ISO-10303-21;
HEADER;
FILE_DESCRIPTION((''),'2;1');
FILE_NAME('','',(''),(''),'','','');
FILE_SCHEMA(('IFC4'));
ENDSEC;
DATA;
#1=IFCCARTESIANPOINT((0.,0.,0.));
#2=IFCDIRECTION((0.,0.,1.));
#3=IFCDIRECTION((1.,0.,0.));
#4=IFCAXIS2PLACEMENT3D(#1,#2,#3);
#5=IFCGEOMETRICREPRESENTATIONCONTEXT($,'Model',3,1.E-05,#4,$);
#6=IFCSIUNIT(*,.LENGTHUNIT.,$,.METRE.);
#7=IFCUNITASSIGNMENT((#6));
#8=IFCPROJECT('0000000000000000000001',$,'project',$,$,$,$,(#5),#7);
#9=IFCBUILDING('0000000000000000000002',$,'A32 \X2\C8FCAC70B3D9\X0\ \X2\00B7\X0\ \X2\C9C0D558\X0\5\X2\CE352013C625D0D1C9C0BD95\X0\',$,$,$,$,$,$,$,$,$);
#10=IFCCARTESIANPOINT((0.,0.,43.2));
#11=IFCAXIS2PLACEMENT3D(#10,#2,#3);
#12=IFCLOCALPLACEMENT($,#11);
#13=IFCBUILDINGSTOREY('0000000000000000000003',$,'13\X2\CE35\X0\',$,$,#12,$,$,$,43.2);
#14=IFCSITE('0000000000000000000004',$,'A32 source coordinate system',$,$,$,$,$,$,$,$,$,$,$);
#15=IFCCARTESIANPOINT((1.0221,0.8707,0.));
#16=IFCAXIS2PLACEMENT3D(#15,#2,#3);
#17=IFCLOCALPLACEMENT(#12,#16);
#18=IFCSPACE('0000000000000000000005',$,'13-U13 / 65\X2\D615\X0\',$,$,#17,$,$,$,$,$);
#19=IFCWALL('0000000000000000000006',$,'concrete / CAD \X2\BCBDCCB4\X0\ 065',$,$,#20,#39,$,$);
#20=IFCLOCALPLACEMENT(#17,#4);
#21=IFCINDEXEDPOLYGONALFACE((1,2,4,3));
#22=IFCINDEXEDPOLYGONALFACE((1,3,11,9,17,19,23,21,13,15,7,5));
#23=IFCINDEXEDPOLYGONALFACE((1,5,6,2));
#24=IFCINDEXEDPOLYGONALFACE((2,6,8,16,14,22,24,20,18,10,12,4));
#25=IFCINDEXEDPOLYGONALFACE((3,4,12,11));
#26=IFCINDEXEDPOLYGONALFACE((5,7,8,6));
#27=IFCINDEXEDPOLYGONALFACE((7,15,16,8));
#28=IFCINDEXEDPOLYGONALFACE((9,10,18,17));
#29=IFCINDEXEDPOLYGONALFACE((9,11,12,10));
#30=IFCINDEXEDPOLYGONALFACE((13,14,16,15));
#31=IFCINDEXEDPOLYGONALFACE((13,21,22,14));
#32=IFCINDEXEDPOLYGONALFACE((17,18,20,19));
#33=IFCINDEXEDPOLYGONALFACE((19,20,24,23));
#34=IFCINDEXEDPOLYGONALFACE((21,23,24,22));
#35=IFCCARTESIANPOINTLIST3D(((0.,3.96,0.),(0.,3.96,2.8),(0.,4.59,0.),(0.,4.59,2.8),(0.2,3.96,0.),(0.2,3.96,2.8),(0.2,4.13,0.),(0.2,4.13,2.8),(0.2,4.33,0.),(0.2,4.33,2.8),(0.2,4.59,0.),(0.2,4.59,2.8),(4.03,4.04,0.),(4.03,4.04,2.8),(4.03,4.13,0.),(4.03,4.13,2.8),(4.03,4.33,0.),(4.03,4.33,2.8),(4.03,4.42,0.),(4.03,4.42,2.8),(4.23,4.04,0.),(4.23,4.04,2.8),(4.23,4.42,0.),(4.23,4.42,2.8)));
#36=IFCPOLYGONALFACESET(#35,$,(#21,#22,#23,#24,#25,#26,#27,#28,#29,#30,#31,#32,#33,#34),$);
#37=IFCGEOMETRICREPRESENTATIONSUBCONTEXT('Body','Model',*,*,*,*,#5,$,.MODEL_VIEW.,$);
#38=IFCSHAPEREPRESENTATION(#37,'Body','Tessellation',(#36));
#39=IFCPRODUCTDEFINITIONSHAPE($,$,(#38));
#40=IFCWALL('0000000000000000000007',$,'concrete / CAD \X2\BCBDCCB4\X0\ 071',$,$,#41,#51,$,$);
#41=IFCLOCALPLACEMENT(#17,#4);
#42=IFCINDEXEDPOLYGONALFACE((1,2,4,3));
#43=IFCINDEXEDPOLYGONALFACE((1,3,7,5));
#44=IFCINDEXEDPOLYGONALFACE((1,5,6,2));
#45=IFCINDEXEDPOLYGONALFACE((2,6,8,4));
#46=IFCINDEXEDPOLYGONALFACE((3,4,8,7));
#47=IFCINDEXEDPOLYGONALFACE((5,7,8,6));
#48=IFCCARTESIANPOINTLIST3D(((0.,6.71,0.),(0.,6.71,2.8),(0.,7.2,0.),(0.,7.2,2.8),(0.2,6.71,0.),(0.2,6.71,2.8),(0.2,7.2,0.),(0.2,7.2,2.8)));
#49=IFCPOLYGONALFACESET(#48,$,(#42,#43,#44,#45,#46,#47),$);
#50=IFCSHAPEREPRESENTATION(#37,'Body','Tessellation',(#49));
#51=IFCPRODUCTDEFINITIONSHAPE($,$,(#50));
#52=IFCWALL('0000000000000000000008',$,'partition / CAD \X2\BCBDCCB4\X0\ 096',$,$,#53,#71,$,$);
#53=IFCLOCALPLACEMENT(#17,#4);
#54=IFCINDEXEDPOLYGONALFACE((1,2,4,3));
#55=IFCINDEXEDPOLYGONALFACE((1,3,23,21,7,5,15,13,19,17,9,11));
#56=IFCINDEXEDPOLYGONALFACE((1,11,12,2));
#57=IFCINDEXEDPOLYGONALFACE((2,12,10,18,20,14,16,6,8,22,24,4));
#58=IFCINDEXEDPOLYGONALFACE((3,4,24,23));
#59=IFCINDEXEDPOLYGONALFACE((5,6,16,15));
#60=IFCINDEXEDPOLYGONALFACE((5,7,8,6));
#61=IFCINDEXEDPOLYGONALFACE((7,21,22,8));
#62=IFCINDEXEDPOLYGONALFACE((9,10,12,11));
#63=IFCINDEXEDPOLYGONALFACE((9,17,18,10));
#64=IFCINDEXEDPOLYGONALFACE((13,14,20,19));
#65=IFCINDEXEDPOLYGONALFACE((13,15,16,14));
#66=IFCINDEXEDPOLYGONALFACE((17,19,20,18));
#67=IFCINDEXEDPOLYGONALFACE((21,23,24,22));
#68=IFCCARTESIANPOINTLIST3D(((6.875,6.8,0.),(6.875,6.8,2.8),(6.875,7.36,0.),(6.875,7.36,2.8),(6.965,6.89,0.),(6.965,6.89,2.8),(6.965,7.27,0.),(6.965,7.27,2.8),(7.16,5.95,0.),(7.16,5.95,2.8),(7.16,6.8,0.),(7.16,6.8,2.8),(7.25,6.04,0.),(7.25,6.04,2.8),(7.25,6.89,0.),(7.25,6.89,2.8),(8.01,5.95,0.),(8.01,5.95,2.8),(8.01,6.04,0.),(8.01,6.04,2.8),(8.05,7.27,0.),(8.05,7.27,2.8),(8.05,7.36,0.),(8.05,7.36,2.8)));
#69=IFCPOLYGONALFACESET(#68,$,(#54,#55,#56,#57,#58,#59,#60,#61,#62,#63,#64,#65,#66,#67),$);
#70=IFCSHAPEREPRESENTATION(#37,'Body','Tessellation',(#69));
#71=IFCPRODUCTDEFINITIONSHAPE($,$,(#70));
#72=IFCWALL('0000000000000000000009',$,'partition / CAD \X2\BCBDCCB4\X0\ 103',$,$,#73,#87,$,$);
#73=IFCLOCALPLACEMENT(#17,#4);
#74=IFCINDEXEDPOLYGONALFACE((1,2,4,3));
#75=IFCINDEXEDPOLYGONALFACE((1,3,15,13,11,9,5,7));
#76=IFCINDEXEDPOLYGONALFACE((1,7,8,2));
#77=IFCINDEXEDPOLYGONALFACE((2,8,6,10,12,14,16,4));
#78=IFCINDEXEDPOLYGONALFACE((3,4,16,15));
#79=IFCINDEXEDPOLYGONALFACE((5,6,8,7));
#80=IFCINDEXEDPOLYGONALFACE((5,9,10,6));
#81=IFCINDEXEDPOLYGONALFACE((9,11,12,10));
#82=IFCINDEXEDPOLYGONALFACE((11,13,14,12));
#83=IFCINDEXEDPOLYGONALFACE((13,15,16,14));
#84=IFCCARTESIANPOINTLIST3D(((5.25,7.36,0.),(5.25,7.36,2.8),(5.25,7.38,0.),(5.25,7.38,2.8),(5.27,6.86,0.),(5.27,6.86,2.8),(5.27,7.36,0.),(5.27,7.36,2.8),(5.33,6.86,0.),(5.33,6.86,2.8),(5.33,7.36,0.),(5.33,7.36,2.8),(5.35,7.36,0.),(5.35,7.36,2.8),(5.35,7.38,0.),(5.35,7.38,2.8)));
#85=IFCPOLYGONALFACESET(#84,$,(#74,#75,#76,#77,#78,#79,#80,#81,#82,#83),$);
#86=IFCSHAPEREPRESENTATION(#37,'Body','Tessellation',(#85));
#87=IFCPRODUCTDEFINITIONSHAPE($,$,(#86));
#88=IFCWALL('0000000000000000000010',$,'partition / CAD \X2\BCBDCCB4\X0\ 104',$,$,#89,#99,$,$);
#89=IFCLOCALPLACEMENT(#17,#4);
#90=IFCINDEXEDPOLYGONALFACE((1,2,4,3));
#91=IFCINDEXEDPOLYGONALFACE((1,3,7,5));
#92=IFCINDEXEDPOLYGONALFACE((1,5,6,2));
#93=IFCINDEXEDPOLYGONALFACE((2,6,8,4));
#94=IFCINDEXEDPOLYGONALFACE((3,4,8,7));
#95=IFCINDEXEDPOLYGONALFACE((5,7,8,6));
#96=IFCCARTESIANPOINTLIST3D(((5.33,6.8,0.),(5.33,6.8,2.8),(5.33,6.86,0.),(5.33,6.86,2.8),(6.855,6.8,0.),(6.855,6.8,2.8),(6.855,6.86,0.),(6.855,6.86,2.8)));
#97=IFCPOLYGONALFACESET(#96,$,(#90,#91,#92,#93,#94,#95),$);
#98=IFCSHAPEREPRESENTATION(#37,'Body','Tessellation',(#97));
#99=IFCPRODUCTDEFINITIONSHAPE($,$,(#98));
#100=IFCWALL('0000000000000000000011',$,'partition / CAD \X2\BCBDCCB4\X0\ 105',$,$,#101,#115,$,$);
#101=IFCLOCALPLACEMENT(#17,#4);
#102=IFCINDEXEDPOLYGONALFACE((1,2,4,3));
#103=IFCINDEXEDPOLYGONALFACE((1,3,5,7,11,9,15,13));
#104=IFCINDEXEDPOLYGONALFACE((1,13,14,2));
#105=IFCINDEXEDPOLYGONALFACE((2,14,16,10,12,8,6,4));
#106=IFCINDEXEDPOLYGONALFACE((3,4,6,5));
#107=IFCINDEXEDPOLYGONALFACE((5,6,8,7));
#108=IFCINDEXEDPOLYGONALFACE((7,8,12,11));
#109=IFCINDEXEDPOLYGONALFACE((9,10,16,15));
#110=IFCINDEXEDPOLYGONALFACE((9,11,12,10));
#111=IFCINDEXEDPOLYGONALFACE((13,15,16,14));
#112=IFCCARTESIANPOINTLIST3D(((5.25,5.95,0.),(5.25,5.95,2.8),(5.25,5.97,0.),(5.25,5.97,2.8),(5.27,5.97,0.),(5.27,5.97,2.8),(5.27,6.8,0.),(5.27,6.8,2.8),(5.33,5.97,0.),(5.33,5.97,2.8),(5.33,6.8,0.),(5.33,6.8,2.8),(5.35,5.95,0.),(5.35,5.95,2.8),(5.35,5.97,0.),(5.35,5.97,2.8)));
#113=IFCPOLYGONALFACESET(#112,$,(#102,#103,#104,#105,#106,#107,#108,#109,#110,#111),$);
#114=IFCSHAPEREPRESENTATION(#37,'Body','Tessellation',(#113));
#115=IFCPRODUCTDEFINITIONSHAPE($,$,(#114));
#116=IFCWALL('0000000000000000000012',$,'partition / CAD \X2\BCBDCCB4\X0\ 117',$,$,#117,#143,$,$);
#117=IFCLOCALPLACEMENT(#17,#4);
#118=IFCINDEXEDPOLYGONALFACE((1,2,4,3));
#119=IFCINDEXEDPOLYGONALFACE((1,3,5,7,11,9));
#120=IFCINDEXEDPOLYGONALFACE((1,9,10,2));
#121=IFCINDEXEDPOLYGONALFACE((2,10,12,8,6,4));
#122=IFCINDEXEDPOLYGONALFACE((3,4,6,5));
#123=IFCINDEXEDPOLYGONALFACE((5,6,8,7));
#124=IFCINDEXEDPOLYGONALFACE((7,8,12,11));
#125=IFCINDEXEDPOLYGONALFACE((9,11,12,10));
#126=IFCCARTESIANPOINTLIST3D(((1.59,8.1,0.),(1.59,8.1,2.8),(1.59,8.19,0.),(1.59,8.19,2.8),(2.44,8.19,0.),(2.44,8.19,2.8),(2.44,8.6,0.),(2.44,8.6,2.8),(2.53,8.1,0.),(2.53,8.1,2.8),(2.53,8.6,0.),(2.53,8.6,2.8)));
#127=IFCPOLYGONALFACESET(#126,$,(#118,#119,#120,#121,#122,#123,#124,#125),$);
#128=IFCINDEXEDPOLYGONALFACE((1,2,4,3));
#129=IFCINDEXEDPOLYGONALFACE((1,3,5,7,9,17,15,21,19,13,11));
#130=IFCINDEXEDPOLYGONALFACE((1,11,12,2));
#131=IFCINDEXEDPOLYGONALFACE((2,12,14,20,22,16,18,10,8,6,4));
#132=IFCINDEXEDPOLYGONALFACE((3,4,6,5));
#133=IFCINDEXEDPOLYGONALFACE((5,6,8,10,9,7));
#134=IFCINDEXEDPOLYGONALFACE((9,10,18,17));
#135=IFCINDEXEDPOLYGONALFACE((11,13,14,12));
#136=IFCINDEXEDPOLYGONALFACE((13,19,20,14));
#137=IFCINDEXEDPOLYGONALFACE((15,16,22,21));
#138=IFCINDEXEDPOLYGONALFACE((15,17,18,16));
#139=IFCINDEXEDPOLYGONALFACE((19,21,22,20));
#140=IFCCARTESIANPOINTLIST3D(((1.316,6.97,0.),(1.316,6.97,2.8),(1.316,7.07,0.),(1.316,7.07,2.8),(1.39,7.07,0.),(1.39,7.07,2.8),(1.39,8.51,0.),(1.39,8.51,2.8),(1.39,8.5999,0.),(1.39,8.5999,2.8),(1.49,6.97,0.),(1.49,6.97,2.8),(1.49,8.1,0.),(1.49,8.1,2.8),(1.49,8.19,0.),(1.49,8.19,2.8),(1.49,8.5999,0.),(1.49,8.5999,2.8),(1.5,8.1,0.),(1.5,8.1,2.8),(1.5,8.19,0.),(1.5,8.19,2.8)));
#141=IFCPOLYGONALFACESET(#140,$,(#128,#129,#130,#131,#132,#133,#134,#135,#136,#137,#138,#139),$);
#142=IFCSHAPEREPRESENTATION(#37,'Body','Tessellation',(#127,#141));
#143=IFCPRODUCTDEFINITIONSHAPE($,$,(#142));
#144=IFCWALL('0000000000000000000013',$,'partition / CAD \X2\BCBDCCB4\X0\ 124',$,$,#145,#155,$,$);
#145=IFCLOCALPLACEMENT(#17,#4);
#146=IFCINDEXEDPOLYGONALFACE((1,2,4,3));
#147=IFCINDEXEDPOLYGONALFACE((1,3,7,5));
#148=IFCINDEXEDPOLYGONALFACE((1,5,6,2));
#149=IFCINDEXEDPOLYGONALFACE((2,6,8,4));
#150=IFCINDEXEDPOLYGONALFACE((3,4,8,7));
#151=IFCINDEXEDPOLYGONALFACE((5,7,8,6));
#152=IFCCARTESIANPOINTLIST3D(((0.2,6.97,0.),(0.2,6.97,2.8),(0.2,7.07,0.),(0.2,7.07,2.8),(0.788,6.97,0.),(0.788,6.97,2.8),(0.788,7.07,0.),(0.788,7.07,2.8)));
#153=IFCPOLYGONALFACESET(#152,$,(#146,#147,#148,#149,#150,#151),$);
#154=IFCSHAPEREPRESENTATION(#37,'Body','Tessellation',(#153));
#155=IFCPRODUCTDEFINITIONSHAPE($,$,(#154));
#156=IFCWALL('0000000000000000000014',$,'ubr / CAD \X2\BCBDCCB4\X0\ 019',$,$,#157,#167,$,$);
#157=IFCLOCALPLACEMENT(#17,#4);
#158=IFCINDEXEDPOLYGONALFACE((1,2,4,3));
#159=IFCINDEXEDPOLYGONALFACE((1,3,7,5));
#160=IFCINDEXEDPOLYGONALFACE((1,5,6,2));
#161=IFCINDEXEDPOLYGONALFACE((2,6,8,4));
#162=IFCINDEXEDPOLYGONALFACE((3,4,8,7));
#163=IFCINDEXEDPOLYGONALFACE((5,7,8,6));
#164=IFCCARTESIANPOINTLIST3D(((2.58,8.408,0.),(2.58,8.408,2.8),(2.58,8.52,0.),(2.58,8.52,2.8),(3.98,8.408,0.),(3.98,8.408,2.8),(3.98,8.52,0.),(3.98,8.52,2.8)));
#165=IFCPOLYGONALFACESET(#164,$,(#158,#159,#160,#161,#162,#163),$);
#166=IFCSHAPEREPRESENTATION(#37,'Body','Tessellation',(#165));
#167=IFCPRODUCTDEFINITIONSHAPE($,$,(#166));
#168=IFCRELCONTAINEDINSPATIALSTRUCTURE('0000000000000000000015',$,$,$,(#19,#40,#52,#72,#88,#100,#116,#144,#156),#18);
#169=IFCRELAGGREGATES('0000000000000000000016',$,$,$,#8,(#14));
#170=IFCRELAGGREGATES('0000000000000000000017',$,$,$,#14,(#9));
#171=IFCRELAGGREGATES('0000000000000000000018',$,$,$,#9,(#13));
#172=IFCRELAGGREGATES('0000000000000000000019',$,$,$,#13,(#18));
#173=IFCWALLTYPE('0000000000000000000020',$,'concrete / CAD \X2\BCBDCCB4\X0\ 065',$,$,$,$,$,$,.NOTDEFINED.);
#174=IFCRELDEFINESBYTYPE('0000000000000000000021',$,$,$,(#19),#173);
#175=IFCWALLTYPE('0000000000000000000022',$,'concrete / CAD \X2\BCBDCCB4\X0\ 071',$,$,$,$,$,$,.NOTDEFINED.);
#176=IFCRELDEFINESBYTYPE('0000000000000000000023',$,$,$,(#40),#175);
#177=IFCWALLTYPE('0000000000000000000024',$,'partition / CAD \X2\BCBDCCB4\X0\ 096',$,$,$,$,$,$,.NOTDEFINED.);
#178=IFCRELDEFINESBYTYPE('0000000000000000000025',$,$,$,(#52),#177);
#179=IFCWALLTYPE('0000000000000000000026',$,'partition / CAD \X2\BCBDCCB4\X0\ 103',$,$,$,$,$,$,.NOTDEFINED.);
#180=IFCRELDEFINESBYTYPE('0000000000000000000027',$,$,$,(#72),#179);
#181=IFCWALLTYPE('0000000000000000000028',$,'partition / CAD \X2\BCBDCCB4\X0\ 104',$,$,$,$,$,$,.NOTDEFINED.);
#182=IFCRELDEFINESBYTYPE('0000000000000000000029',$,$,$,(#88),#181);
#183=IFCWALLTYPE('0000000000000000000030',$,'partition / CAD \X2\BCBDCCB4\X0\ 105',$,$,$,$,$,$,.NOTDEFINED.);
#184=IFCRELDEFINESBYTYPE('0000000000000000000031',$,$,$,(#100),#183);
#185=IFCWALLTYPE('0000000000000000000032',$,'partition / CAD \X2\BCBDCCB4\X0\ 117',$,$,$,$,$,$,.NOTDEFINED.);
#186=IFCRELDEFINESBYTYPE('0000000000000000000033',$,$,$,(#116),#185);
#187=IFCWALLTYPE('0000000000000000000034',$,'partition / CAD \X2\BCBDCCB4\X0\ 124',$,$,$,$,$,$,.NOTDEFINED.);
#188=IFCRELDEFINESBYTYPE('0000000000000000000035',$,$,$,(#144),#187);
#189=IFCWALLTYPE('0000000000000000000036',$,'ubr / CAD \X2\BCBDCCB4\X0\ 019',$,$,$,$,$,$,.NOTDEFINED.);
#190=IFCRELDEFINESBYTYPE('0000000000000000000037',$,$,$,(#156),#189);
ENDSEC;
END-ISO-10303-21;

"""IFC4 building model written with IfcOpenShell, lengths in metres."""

from ifc_helpers import new_model, si_unit, frame, origin, origin_with_axes, place, context, subcontext, project, spatial, polyline, outline, extrude, source, transform, mapped, type_object, type_shapes, element, save


model = new_model("IFC4")

# Units and contexts
model_context = context("Model", 3, precision=1e-05, world=origin_with_axes())
body_context = subcontext(model_context, "Body", "Model", "MODEL_VIEW")
ifc_project = project(units=[si_unit("LENGTHUNIT", "METRE")], contexts=[model_context])

# Site, building, storey, space
storey_placement = place(None, frame((0.0, 0.0, 43.2), z_axis=(0.0, 0.0, 1.0), x_axis=(1.0, 0.0, 0.0)))
space_placement = place(storey_placement, frame((1.0221, 0.8707, 0.0), z_axis=(0.0, 0.0, 1.0), x_axis=(1.0, 0.0, 0.0)))
site = spatial("IfcSite", under=ifc_project, Name="A32 source coordinate system")
building = spatial("IfcBuilding", under=site, Name="A32 주거동 · 지하5층–옥탑지붕")
storey = spatial("IfcBuildingStorey", under=building, at=storey_placement, Name="13층", Elevation=43.2)
space = spatial("IfcSpace", under=storey, at=space_placement, Name="13-U13 / 65형")

# Walls
wall_type_1 = type_object("IfcWallType", Name="concrete / CAD 벽체 065", PredefinedType="NOTDEFINED")
shared_shape_1 = source(origin(), body_context, "Body", "SweptSolid", [
    extrude(outline(polyline([(0.2, 4.59), (0.2, 4.33), (4.03, 4.33), (4.03, 4.42), (4.23, 4.42), (4.23, 4.04), (4.03, 4.04), (4.03, 4.13), (0.2, 4.13), (0.2, 3.96), (0.0, 3.96), (0.0, 4.59), (0.2, 4.59)])), origin(), (0.0, 0.0, 1.0), 2.8),
])
type_shapes(wall_type_1, [shared_shape_1])
wall_1_placement = place(space_placement, origin_with_axes())
element("IfcWall", 1, at=wall_1_placement, inside=space, type_object=wall_type_1, Name="concrete / CAD 벽체 065", context=body_context, shape_type="MappedRepresentation", body=[
    mapped(shared_shape_1, transform((0.0, 0.0, 0.0), scale=1.0)),
])
wall_type_2 = type_object("IfcWallType", Name="concrete / CAD 벽체 071", PredefinedType="NOTDEFINED")
shared_shape_2 = source(origin(), body_context, "Body", "SweptSolid", [
    extrude(outline(polyline([(0.2, 6.71), (0.0, 6.71), (0.0, 7.2), (0.2, 7.2), (0.2, 6.71)])), origin(), (0.0, 0.0, 1.0), 2.8),
])
type_shapes(wall_type_2, [shared_shape_2])
wall_2_placement = place(space_placement, origin_with_axes())
element("IfcWall", 2, at=wall_2_placement, inside=space, type_object=wall_type_2, Name="concrete / CAD 벽체 071", context=body_context, shape_type="MappedRepresentation", body=[
    mapped(shared_shape_2, transform((0.0, 0.0, 0.0), scale=1.0)),
])
wall_type_3 = type_object("IfcWallType", Name="partition / CAD 벽체 096", PredefinedType="NOTDEFINED")
shared_shape_3 = source(origin(), body_context, "Body", "SweptSolid", [
    extrude(outline(polyline([(7.25, 6.04), (8.01, 6.04), (8.01, 5.95), (7.16, 5.95), (7.16, 6.8), (6.875, 6.8), (6.875, 7.36), (8.05, 7.36), (8.05, 7.27), (6.965, 7.27), (6.965, 6.89), (7.25, 6.89), (7.25, 6.04)])), origin(), (0.0, 0.0, 1.0), 2.8),
])
type_shapes(wall_type_3, [shared_shape_3])
wall_3_placement = place(space_placement, origin_with_axes())
element("IfcWall", 3, at=wall_3_placement, inside=space, type_object=wall_type_3, Name="partition / CAD 벽체 096", context=body_context, shape_type="MappedRepresentation", body=[
    mapped(shared_shape_3, transform((0.0, 0.0, 0.0), scale=1.0)),
])
wall_type_4 = type_object("IfcWallType", Name="partition / CAD 벽체 103", PredefinedType="NOTDEFINED")
shared_shape_4 = source(origin(), body_context, "Body", "SweptSolid", [
    extrude(outline(polyline([(5.27, 7.36), (5.25, 7.36), (5.25, 7.38), (5.35, 7.38), (5.35, 7.36), (5.33, 7.36), (5.33, 6.86), (5.27, 6.86), (5.27, 7.36)])), origin(), (0.0, 0.0, 1.0), 2.8),
])
type_shapes(wall_type_4, [shared_shape_4])
wall_4_placement = place(space_placement, origin_with_axes())
element("IfcWall", 4, at=wall_4_placement, inside=space, type_object=wall_type_4, Name="partition / CAD 벽체 103", context=body_context, shape_type="MappedRepresentation", body=[
    mapped(shared_shape_4, transform((0.0, 0.0, 0.0), scale=1.0)),
])
wall_type_5 = type_object("IfcWallType", Name="partition / CAD 벽체 104", PredefinedType="NOTDEFINED")
shared_shape_5 = source(origin(), body_context, "Body", "SweptSolid", [
    extrude(outline(polyline([(6.855, 6.86), (6.855, 6.8), (5.33, 6.8), (5.33, 6.86), (6.855, 6.86)])), origin(), (0.0, 0.0, 1.0), 2.8),
])
type_shapes(wall_type_5, [shared_shape_5])
wall_5_placement = place(space_placement, origin_with_axes())
element("IfcWall", 5, at=wall_5_placement, inside=space, type_object=wall_type_5, Name="partition / CAD 벽체 104", context=body_context, shape_type="MappedRepresentation", body=[
    mapped(shared_shape_5, transform((0.0, 0.0, 0.0), scale=1.0)),
])
wall_type_6 = type_object("IfcWallType", Name="partition / CAD 벽체 105", PredefinedType="NOTDEFINED")
shared_shape_6 = source(origin(), body_context, "Body", "SweptSolid", [
    extrude(outline(polyline([(5.25, 5.97), (5.27, 5.97), (5.27, 6.8), (5.33, 6.8), (5.33, 5.97), (5.35, 5.97), (5.35, 5.95), (5.25, 5.95), (5.25, 5.97)])), origin(), (0.0, 0.0, 1.0), 2.8),
])
type_shapes(wall_type_6, [shared_shape_6])
wall_6_placement = place(space_placement, origin_with_axes())
element("IfcWall", 6, at=wall_6_placement, inside=space, type_object=wall_type_6, Name="partition / CAD 벽체 105", context=body_context, shape_type="MappedRepresentation", body=[
    mapped(shared_shape_6, transform((0.0, 0.0, 0.0), scale=1.0)),
])
wall_type_7 = type_object("IfcWallType", Name="partition / CAD 벽체 117", PredefinedType="NOTDEFINED")
shared_shape_7 = source(origin(), body_context, "Body", "SweptSolid", [
    extrude(outline(polyline([(2.53, 8.1), (1.59, 8.1), (1.59, 8.19), (2.44, 8.19), (2.44, 8.6), (2.53, 8.6), (2.53, 8.1)])), origin(), (0.0, 0.0, 1.0), 2.8),
    extrude(outline(polyline([(1.49, 8.1), (1.49, 6.97), (1.316, 6.97), (1.316, 7.07), (1.39, 7.07), (1.39, 8.51), (1.39, 8.5999), (1.49, 8.5999), (1.49, 8.19), (1.5, 8.19), (1.5, 8.1), (1.49, 8.1)])), origin(), (0.0, 0.0, 1.0), 2.8),
])
type_shapes(wall_type_7, [shared_shape_7])
wall_7_placement = place(space_placement, origin_with_axes())
element("IfcWall", 7, at=wall_7_placement, inside=space, type_object=wall_type_7, Name="partition / CAD 벽체 117", context=body_context, shape_type="MappedRepresentation", body=[
    mapped(shared_shape_7, transform((0.0, 0.0, 0.0), scale=1.0)),
])
wall_type_8 = type_object("IfcWallType", Name="partition / CAD 벽체 124", PredefinedType="NOTDEFINED")
shared_shape_8 = source(origin(), body_context, "Body", "SweptSolid", [
    extrude(outline(polyline([(0.788, 7.07), (0.788, 6.97), (0.2, 6.97), (0.2, 7.07), (0.788, 7.07)])), origin(), (0.0, 0.0, 1.0), 2.8),
])
type_shapes(wall_type_8, [shared_shape_8])
wall_8_placement = place(space_placement, origin_with_axes())
element("IfcWall", 8, at=wall_8_placement, inside=space, type_object=wall_type_8, Name="partition / CAD 벽체 124", context=body_context, shape_type="MappedRepresentation", body=[
    mapped(shared_shape_8, transform((0.0, 0.0, 0.0), scale=1.0)),
])
wall_type_9 = type_object("IfcWallType", Name="ubr / CAD 벽체 019", PredefinedType="NOTDEFINED")
shared_shape_9 = source(origin(), body_context, "Body", "SweptSolid", [
    extrude(outline(polyline([(3.98, 8.408), (2.58, 8.408), (2.58, 8.52), (3.98, 8.52), (3.98, 8.408)])), origin(), (0.0, 0.0, 1.0), 2.8),
])
type_shapes(wall_type_9, [shared_shape_9])
wall_9_placement = place(space_placement, origin_with_axes())
element("IfcWall", 9, at=wall_9_placement, inside=space, type_object=wall_type_9, Name="ubr / CAD 벽체 019", context=body_context, shape_type="MappedRepresentation", body=[
    mapped(shared_shape_9, transform((0.0, 0.0, 0.0), scale=1.0)),
])

save(model, "model.ifc")
